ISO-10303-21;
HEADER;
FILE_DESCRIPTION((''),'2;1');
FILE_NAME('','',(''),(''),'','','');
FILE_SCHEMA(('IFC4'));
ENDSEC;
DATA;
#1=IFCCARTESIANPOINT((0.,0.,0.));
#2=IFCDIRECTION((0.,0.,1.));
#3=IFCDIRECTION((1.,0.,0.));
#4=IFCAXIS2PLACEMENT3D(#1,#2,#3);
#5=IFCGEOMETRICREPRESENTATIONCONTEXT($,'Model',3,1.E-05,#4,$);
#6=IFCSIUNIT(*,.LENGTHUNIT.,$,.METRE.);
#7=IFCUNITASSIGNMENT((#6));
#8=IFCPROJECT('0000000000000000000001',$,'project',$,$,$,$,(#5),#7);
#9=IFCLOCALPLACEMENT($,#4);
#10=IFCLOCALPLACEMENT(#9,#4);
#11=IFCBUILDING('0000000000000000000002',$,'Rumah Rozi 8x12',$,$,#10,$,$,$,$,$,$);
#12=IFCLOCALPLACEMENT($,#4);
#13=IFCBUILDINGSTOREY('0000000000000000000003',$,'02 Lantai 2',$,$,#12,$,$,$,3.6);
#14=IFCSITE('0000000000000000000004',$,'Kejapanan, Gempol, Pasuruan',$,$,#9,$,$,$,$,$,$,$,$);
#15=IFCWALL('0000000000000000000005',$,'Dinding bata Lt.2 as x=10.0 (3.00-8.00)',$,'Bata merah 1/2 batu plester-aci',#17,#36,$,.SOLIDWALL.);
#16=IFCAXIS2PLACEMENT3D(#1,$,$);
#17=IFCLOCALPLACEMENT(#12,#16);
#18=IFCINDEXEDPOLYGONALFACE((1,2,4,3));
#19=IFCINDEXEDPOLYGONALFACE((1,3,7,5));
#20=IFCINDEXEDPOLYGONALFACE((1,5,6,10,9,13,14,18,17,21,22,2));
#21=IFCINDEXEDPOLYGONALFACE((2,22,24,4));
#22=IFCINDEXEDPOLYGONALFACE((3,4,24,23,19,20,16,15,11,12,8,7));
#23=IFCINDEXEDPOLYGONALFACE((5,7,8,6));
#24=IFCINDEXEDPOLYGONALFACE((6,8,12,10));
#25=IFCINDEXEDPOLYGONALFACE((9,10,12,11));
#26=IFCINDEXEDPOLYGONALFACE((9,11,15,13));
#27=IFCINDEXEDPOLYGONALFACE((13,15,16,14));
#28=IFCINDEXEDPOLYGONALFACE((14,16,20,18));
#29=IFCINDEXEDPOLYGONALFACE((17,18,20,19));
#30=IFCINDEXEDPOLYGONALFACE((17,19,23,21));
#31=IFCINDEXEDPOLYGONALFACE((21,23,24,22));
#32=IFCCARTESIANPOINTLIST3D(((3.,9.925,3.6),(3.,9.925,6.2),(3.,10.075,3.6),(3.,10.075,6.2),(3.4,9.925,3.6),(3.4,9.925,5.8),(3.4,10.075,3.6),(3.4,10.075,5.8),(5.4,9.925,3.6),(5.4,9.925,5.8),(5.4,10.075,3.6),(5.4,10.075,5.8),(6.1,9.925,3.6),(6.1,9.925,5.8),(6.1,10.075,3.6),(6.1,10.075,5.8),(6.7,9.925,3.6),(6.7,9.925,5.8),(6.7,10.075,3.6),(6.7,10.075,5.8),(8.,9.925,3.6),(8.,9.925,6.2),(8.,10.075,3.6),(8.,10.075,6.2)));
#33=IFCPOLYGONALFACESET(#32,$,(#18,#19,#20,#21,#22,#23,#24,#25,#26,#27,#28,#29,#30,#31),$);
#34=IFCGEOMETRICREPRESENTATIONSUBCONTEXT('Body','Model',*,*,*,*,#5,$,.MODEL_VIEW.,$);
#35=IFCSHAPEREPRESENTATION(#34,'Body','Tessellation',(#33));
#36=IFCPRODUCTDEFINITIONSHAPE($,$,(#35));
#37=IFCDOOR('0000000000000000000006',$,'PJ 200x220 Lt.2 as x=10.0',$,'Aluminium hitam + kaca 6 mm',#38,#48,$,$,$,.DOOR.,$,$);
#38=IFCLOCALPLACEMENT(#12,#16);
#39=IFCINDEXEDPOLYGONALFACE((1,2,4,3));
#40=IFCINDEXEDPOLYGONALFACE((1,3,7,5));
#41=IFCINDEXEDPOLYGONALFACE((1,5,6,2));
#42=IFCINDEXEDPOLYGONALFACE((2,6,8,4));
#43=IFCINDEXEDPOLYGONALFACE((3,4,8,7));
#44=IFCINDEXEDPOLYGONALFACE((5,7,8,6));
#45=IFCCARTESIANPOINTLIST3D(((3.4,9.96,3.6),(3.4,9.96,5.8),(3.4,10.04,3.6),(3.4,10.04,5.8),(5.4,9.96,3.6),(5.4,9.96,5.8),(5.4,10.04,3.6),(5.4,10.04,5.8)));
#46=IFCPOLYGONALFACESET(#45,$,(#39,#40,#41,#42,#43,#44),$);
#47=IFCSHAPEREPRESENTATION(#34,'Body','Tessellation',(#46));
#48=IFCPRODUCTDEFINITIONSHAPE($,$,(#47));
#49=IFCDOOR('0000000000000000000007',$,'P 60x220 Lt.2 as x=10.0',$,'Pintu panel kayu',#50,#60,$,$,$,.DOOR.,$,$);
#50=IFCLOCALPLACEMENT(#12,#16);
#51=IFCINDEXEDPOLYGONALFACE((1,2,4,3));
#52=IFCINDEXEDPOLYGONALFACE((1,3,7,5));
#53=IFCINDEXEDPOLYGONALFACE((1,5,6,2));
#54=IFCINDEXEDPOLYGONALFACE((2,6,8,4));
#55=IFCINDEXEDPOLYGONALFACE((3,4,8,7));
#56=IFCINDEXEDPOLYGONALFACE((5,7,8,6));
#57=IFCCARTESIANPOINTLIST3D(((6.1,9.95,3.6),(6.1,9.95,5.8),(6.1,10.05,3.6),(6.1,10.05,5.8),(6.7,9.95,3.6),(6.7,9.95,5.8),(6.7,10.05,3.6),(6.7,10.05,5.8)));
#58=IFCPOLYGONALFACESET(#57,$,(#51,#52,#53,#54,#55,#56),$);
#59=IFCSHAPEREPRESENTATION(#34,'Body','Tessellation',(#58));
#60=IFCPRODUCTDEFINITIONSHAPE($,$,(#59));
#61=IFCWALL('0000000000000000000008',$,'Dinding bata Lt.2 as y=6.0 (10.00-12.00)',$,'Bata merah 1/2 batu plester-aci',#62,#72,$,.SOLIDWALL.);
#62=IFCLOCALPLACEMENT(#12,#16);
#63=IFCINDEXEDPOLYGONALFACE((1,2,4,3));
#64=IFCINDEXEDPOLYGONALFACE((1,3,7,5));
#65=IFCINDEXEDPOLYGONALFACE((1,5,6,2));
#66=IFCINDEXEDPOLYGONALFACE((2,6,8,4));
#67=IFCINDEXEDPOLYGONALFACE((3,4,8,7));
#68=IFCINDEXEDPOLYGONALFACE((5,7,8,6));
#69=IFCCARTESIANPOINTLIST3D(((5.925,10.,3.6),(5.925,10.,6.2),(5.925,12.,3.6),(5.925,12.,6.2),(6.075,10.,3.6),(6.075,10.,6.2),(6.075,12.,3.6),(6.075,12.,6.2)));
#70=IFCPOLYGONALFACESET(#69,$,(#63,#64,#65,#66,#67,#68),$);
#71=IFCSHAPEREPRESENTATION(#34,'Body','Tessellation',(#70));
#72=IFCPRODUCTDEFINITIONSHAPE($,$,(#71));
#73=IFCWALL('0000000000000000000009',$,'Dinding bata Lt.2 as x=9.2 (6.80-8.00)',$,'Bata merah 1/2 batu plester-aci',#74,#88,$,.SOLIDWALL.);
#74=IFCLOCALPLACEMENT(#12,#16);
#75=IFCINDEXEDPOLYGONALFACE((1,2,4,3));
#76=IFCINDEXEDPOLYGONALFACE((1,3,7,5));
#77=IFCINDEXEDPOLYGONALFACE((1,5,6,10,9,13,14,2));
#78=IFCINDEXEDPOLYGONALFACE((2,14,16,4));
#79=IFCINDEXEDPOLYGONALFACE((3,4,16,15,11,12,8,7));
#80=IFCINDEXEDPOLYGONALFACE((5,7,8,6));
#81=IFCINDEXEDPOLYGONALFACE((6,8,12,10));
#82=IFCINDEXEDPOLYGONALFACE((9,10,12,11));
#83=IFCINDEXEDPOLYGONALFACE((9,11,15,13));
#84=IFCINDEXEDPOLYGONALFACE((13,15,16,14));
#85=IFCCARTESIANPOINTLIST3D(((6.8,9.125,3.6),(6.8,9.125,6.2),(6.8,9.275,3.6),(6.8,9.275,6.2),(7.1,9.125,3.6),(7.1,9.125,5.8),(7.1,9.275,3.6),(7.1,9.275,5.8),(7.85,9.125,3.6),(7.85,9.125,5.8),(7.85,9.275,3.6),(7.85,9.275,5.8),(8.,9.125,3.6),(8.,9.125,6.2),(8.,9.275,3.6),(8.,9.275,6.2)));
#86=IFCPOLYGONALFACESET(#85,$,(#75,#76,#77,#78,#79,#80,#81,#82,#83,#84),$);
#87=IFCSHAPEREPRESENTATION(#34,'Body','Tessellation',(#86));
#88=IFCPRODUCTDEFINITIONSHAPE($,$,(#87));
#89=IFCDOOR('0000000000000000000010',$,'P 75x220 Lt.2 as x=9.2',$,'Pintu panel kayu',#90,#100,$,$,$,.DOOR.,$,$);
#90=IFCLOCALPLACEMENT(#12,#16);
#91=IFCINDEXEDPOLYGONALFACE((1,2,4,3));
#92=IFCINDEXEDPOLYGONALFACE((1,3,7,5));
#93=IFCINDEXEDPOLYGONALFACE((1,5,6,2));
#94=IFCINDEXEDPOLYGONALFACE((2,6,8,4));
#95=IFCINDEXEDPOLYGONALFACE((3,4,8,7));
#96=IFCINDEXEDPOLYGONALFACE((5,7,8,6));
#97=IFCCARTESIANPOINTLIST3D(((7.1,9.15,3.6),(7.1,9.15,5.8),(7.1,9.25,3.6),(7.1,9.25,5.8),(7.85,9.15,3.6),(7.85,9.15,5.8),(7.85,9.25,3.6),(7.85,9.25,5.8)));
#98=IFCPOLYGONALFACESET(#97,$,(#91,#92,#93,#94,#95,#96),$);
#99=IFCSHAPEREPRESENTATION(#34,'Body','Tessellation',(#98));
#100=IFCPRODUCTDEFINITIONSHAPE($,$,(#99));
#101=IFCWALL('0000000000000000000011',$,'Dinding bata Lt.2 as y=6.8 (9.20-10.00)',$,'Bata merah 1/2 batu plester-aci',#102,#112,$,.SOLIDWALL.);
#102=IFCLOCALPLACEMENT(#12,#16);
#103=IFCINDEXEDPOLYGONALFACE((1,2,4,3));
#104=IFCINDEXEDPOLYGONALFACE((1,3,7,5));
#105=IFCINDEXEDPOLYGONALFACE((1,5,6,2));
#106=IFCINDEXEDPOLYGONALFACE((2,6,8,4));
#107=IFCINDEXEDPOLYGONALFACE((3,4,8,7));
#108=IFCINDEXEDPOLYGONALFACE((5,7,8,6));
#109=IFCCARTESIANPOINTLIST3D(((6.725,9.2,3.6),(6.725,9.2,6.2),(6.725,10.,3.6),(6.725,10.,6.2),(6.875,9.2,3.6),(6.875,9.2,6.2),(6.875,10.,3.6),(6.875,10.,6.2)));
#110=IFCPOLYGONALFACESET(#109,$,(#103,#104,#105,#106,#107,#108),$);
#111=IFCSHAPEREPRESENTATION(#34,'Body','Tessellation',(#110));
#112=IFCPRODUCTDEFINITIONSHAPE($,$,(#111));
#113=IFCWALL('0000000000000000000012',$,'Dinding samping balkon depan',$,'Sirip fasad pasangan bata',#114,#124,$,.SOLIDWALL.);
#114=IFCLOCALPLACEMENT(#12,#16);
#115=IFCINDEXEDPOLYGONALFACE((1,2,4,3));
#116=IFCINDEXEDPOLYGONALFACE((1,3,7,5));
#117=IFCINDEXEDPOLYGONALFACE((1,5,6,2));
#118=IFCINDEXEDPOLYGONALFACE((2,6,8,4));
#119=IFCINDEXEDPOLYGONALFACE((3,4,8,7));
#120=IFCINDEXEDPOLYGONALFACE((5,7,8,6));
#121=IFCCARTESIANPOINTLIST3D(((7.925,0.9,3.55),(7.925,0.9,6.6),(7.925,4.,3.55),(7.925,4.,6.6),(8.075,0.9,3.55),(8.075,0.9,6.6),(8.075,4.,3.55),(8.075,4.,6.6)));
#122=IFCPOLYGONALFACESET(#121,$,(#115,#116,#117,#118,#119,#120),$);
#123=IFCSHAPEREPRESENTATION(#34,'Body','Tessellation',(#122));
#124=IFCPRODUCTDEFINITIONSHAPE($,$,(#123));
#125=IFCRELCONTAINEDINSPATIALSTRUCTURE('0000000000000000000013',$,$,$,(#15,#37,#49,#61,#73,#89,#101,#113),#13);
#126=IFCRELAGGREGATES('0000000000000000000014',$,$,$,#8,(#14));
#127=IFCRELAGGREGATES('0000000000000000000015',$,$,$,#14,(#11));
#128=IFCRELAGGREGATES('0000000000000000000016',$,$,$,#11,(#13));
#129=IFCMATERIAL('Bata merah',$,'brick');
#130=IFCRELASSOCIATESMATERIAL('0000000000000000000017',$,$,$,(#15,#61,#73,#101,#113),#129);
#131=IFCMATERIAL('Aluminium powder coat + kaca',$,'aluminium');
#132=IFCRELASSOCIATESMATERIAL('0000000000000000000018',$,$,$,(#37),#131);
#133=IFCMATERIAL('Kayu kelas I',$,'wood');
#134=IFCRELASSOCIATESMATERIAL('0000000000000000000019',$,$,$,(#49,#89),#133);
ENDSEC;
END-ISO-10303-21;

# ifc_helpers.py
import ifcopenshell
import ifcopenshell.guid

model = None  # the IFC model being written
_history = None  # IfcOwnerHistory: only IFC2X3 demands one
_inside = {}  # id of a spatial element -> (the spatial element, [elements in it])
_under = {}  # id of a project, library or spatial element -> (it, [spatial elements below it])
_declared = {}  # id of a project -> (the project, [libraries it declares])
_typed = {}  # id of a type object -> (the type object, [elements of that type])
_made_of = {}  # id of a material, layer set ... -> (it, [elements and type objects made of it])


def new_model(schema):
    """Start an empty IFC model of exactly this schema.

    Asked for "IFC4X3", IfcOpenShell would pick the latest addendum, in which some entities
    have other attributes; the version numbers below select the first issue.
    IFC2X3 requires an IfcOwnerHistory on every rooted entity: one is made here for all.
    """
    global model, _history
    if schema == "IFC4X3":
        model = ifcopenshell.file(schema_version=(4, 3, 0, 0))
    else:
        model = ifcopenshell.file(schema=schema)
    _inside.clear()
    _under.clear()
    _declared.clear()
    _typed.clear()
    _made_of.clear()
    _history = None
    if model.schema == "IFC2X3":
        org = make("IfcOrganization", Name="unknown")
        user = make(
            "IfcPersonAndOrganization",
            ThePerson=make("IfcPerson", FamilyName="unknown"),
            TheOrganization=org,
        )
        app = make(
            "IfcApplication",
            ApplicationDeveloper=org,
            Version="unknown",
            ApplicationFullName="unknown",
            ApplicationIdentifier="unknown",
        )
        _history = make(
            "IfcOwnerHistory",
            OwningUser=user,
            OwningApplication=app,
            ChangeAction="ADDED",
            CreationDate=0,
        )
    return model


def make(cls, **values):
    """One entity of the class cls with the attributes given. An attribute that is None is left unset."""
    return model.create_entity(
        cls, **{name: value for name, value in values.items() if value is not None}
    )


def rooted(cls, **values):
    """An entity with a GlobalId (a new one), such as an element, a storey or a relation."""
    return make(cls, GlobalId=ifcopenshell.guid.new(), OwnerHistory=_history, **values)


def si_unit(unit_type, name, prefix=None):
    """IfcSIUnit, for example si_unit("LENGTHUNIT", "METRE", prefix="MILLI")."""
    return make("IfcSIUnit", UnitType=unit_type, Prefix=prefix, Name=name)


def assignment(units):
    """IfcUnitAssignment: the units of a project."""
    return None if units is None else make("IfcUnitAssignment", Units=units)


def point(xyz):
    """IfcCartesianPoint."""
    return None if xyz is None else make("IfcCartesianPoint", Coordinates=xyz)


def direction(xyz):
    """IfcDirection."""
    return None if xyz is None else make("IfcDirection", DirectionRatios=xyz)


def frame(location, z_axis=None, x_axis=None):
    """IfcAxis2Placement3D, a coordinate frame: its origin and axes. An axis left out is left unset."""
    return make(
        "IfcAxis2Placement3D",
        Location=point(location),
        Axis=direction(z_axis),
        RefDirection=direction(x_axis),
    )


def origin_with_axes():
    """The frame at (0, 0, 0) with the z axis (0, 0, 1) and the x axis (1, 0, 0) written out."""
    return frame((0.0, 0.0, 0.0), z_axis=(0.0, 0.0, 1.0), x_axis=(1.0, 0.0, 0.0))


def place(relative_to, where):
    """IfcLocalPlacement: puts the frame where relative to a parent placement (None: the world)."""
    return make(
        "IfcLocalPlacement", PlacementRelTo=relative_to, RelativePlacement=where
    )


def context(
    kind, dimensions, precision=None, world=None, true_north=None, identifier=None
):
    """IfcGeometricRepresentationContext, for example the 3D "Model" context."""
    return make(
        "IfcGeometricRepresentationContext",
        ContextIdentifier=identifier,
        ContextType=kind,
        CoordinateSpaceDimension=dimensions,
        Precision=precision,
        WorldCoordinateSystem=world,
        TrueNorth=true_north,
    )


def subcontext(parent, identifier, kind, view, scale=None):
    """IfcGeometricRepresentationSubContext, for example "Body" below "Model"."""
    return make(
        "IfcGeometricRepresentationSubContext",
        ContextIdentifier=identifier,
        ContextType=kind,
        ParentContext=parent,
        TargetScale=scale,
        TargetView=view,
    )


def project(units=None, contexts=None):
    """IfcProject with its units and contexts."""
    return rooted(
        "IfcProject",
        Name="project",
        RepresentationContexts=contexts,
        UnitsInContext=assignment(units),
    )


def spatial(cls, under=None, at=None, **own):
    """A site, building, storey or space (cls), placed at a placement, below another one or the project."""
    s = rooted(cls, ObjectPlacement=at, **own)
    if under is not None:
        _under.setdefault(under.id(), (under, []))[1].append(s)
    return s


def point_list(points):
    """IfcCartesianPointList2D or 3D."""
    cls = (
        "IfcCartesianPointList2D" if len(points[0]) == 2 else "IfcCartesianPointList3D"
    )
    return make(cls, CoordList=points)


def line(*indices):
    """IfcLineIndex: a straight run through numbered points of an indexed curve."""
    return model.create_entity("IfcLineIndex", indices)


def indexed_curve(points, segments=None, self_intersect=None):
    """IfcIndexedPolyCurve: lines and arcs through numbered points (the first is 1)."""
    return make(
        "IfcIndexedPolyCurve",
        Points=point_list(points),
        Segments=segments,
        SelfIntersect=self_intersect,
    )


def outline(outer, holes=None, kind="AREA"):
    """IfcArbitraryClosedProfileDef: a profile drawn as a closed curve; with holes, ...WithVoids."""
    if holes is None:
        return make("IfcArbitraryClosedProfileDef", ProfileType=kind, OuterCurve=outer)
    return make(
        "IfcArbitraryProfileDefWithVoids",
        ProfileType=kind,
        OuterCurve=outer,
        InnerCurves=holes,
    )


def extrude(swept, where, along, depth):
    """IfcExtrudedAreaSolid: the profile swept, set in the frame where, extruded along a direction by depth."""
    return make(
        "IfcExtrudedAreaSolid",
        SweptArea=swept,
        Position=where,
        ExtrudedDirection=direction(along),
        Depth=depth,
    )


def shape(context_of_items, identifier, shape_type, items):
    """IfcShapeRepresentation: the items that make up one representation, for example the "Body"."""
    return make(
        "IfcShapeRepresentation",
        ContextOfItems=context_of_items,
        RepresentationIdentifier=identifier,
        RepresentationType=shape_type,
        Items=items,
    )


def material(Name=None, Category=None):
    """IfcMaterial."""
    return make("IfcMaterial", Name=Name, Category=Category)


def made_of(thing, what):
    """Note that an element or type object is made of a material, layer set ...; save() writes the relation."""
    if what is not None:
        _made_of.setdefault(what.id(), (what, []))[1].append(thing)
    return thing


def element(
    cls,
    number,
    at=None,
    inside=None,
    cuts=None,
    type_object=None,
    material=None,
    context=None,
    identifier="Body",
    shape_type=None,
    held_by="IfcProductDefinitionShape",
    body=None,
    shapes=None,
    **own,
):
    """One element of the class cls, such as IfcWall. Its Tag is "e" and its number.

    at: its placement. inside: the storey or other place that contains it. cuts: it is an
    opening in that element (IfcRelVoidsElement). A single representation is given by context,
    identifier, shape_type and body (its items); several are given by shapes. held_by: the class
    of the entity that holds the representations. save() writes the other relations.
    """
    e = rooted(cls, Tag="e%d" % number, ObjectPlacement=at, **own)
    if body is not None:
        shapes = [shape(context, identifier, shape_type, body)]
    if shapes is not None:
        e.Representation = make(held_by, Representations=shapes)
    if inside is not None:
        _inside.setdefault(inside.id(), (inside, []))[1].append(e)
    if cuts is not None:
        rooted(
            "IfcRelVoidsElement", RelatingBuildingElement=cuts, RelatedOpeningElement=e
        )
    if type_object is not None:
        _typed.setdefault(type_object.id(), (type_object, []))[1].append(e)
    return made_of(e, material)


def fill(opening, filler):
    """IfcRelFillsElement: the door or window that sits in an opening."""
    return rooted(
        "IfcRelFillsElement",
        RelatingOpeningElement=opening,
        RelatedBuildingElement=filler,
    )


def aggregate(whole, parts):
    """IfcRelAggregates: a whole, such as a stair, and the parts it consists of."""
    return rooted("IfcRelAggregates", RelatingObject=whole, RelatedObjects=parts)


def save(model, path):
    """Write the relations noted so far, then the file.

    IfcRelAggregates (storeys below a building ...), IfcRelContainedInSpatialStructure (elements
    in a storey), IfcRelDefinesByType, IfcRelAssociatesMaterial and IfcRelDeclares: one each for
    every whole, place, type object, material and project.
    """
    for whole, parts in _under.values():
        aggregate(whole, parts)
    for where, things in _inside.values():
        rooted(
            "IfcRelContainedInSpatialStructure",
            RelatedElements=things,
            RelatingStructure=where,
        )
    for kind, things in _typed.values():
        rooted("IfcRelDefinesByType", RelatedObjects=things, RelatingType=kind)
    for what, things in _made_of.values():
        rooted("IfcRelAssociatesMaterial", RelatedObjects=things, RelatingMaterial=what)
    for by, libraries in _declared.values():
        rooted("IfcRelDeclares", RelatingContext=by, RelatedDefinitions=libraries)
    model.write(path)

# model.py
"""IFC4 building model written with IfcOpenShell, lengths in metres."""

from ifc_helpers import new_model, si_unit, frame, origin_with_axes, place, context, subcontext, project, spatial, line, indexed_curve, outline, extrude, material, element, fill, save


model = new_model("IFC4")

# Units and contexts
model_context = context("Model", 3, precision=1e-05, world=origin_with_axes())
body_context = subcontext(model_context, "Body", "Model", "MODEL_VIEW")
ifc_project = project(units=[si_unit("LENGTHUNIT", "METRE")], contexts=[model_context])

# Site, building, storey
site_placement = place(None, origin_with_axes())
site = spatial("IfcSite", under=ifc_project, at=site_placement, Name="Kejapanan, Gempol, Pasuruan")
building_placement = place(site_placement, origin_with_axes())
building = spatial("IfcBuilding", under=site, at=building_placement, Name="Rumah Rozi 8x12")
storey_placement = place(None, origin_with_axes())
storey = spatial("IfcBuildingStorey", under=building, at=storey_placement, Name="02 Lantai 2", Elevation=3.6)

# Shared definitions
ifc_material_1 = material(Name="Bata merah", Category="brick")
ifc_material_2 = material(Name="Aluminium powder coat + kaca", Category="aluminium")

# Shared definitions
ifc_material_3 = material(Name="Kayu kelas I", Category="wood")

# Wall, openings, doors
wall_1_placement = place(storey_placement, origin_with_axes())
wall_1 = element("IfcWall", 1, at=wall_1_placement, inside=storey, material=ifc_material_1, Name="Dinding bata Lt.2 as x=10.0 (3.00-8.00)", ObjectType="Bata merah 1/2 batu plester-aci", PredefinedType="SOLIDWALL", context=body_context, shape_type="SweptSolid", body=[
    extrude(outline(indexed_curve([(3.0, 9.925), (8.0, 9.925), (8.0, 10.075), (3.0, 10.075)], segments=[line(1, 2, 3, 4, 1)])), frame((0.0, 0.0, 3.6), z_axis=(0.0, 0.0, 1.0), x_axis=(1.0, 0.0, 0.0)), (0.0, 0.0, 1.0), 2.6),
])
opening_1_placement = place(wall_1_placement, origin_with_axes())
opening_1 = element("IfcOpeningElement", 2, at=opening_1_placement, cuts=wall_1, context=body_context, shape_type="SweptSolid", body=[
    extrude(outline(indexed_curve([(3.4, 9.915), (5.4, 9.915), (5.4, 10.085), (3.4, 10.085)], segments=[line(1, 2, 3, 4, 1)])), frame((0.0, 0.0, 3.6), z_axis=(0.0, 0.0, 1.0), x_axis=(1.0, 0.0, 0.0)), (0.0, 0.0, 1.0), 2.2),
])
opening_2_placement = place(wall_1_placement, origin_with_axes())
opening_2 = element("IfcOpeningElement", 3, at=opening_2_placement, cuts=wall_1, context=body_context, shape_type="SweptSolid", body=[
    extrude(outline(indexed_curve([(6.1, 9.915), (6.7, 9.915), (6.7, 10.085), (6.1, 10.085)], segments=[line(1, 2, 3, 4, 1)])), frame((0.0, 0.0, 3.6), z_axis=(0.0, 0.0, 1.0), x_axis=(1.0, 0.0, 0.0)), (0.0, 0.0, 1.0), 2.2),
])
door_1_placement = place(storey_placement, origin_with_axes())
door_1 = element("IfcDoor", 4, at=door_1_placement, inside=storey, material=ifc_material_2, Name="PJ 200x220 Lt.2 as x=10.0", ObjectType="Aluminium hitam + kaca 6 mm", PredefinedType="DOOR", context=body_context, shape_type="SweptSolid", body=[
    extrude(outline(indexed_curve([(3.4, 9.96), (5.4, 9.96), (5.4, 10.04), (3.4, 10.04)], segments=[line(1, 2, 3, 4, 1)])), frame((0.0, 0.0, 3.6), z_axis=(0.0, 0.0, 1.0), x_axis=(1.0, 0.0, 0.0)), (0.0, 0.0, 1.0), 2.2),
])
fill(opening_1, door_1)
door_2_placement = place(storey_placement, origin_with_axes())
door_2 = element("IfcDoor", 5, at=door_2_placement, inside=storey, material=ifc_material_3, Name="P 60x220 Lt.2 as x=10.0", ObjectType="Pintu panel kayu", PredefinedType="DOOR", context=body_context, shape_type="SweptSolid", body=[
    extrude(outline(indexed_curve([(6.1, 9.95), (6.7, 9.95), (6.7, 10.05), (6.1, 10.05)], segments=[line(1, 2, 3, 4, 1)])), frame((0.0, 0.0, 3.6), z_axis=(0.0, 0.0, 1.0), x_axis=(1.0, 0.0, 0.0)), (0.0, 0.0, 1.0), 2.2),
])
fill(opening_2, door_2)

# Wall
wall_2_placement = place(storey_placement, origin_with_axes())
element("IfcWall", 6, at=wall_2_placement, inside=storey, material=ifc_material_1, Name="Dinding bata Lt.2 as y=6.0 (10.00-12.00)", ObjectType="Bata merah 1/2 batu plester-aci", PredefinedType="SOLIDWALL", context=body_context, shape_type="SweptSolid", body=[
    extrude(outline(indexed_curve([(5.925, 10.0), (6.075, 10.0), (6.075, 12.0), (5.925, 12.0)], segments=[line(1, 2, 3, 4, 1)])), frame((0.0, 0.0, 3.6), z_axis=(0.0, 0.0, 1.0), x_axis=(1.0, 0.0, 0.0)), (0.0, 0.0, 1.0), 2.6),
])

# Wall, opening, door
wall_3_placement = place(storey_placement, origin_with_axes())
wall_3 = element("IfcWall", 7, at=wall_3_placement, inside=storey, material=ifc_material_1, Name="Dinding bata Lt.2 as x=9.2 (6.80-8.00)", ObjectType="Bata merah 1/2 batu plester-aci", PredefinedType="SOLIDWALL", context=body_context, shape_type="SweptSolid", body=[
    extrude(outline(indexed_curve([(6.8, 9.125), (8.0, 9.125), (8.0, 9.275), (6.8, 9.275)], segments=[line(1, 2, 3, 4, 1)])), frame((0.0, 0.0, 3.6), z_axis=(0.0, 0.0, 1.0), x_axis=(1.0, 0.0, 0.0)), (0.0, 0.0, 1.0), 2.6),
])
opening_3_placement = place(wall_3_placement, origin_with_axes())
opening_3 = element("IfcOpeningElement", 8, at=opening_3_placement, cuts=wall_3, context=body_context, shape_type="SweptSolid", body=[
    extrude(outline(indexed_curve([(7.1, 9.115), (7.85, 9.115), (7.85, 9.285), (7.1, 9.285)], segments=[line(1, 2, 3, 4, 1)])), frame((0.0, 0.0, 3.6), z_axis=(0.0, 0.0, 1.0), x_axis=(1.0, 0.0, 0.0)), (0.0, 0.0, 1.0), 2.2),
])
door_3_placement = place(storey_placement, origin_with_axes())
door_3 = element("IfcDoor", 9, at=door_3_placement, inside=storey, material=ifc_material_3, Name="P 75x220 Lt.2 as x=9.2", ObjectType="Pintu panel kayu", PredefinedType="DOOR", context=body_context, shape_type="SweptSolid", body=[
    extrude(outline(indexed_curve([(7.1, 9.15), (7.85, 9.15), (7.85, 9.25), (7.1, 9.25)], segments=[line(1, 2, 3, 4, 1)])), frame((0.0, 0.0, 3.6), z_axis=(0.0, 0.0, 1.0), x_axis=(1.0, 0.0, 0.0)), (0.0, 0.0, 1.0), 2.2),
])
fill(opening_3, door_3)

# Walls
wall_4_placement = place(storey_placement, origin_with_axes())
element("IfcWall", 10, at=wall_4_placement, inside=storey, material=ifc_material_1, Name="Dinding bata Lt.2 as y=6.8 (9.20-10.00)", ObjectType="Bata merah 1/2 batu plester-aci", PredefinedType="SOLIDWALL", context=body_context, shape_type="SweptSolid", body=[
    extrude(outline(indexed_curve([(6.725, 9.2), (6.875, 9.2), (6.875, 10.0), (6.725, 10.0)], segments=[line(1, 2, 3, 4, 1)])), frame((0.0, 0.0, 3.6), z_axis=(0.0, 0.0, 1.0), x_axis=(1.0, 0.0, 0.0)), (0.0, 0.0, 1.0), 2.6),
])
wall_5_placement = place(storey_placement, origin_with_axes())
element("IfcWall", 11, at=wall_5_placement, inside=storey, material=ifc_material_1, Name="Dinding samping balkon depan", ObjectType="Sirip fasad pasangan bata", PredefinedType="SOLIDWALL", context=body_context, shape_type="SweptSolid", body=[
    extrude(outline(indexed_curve([(7.925, 0.9), (8.075, 0.9), (8.075, 4.0), (7.925, 4.0)], segments=[line(1, 2, 3, 4, 1)])), frame((0.0, 0.0, 3.55), z_axis=(0.0, 0.0, 1.0), x_axis=(1.0, 0.0, 0.0)), (0.0, 0.0, 1.0), 3.05),
])

save(model, "model.ifc")
